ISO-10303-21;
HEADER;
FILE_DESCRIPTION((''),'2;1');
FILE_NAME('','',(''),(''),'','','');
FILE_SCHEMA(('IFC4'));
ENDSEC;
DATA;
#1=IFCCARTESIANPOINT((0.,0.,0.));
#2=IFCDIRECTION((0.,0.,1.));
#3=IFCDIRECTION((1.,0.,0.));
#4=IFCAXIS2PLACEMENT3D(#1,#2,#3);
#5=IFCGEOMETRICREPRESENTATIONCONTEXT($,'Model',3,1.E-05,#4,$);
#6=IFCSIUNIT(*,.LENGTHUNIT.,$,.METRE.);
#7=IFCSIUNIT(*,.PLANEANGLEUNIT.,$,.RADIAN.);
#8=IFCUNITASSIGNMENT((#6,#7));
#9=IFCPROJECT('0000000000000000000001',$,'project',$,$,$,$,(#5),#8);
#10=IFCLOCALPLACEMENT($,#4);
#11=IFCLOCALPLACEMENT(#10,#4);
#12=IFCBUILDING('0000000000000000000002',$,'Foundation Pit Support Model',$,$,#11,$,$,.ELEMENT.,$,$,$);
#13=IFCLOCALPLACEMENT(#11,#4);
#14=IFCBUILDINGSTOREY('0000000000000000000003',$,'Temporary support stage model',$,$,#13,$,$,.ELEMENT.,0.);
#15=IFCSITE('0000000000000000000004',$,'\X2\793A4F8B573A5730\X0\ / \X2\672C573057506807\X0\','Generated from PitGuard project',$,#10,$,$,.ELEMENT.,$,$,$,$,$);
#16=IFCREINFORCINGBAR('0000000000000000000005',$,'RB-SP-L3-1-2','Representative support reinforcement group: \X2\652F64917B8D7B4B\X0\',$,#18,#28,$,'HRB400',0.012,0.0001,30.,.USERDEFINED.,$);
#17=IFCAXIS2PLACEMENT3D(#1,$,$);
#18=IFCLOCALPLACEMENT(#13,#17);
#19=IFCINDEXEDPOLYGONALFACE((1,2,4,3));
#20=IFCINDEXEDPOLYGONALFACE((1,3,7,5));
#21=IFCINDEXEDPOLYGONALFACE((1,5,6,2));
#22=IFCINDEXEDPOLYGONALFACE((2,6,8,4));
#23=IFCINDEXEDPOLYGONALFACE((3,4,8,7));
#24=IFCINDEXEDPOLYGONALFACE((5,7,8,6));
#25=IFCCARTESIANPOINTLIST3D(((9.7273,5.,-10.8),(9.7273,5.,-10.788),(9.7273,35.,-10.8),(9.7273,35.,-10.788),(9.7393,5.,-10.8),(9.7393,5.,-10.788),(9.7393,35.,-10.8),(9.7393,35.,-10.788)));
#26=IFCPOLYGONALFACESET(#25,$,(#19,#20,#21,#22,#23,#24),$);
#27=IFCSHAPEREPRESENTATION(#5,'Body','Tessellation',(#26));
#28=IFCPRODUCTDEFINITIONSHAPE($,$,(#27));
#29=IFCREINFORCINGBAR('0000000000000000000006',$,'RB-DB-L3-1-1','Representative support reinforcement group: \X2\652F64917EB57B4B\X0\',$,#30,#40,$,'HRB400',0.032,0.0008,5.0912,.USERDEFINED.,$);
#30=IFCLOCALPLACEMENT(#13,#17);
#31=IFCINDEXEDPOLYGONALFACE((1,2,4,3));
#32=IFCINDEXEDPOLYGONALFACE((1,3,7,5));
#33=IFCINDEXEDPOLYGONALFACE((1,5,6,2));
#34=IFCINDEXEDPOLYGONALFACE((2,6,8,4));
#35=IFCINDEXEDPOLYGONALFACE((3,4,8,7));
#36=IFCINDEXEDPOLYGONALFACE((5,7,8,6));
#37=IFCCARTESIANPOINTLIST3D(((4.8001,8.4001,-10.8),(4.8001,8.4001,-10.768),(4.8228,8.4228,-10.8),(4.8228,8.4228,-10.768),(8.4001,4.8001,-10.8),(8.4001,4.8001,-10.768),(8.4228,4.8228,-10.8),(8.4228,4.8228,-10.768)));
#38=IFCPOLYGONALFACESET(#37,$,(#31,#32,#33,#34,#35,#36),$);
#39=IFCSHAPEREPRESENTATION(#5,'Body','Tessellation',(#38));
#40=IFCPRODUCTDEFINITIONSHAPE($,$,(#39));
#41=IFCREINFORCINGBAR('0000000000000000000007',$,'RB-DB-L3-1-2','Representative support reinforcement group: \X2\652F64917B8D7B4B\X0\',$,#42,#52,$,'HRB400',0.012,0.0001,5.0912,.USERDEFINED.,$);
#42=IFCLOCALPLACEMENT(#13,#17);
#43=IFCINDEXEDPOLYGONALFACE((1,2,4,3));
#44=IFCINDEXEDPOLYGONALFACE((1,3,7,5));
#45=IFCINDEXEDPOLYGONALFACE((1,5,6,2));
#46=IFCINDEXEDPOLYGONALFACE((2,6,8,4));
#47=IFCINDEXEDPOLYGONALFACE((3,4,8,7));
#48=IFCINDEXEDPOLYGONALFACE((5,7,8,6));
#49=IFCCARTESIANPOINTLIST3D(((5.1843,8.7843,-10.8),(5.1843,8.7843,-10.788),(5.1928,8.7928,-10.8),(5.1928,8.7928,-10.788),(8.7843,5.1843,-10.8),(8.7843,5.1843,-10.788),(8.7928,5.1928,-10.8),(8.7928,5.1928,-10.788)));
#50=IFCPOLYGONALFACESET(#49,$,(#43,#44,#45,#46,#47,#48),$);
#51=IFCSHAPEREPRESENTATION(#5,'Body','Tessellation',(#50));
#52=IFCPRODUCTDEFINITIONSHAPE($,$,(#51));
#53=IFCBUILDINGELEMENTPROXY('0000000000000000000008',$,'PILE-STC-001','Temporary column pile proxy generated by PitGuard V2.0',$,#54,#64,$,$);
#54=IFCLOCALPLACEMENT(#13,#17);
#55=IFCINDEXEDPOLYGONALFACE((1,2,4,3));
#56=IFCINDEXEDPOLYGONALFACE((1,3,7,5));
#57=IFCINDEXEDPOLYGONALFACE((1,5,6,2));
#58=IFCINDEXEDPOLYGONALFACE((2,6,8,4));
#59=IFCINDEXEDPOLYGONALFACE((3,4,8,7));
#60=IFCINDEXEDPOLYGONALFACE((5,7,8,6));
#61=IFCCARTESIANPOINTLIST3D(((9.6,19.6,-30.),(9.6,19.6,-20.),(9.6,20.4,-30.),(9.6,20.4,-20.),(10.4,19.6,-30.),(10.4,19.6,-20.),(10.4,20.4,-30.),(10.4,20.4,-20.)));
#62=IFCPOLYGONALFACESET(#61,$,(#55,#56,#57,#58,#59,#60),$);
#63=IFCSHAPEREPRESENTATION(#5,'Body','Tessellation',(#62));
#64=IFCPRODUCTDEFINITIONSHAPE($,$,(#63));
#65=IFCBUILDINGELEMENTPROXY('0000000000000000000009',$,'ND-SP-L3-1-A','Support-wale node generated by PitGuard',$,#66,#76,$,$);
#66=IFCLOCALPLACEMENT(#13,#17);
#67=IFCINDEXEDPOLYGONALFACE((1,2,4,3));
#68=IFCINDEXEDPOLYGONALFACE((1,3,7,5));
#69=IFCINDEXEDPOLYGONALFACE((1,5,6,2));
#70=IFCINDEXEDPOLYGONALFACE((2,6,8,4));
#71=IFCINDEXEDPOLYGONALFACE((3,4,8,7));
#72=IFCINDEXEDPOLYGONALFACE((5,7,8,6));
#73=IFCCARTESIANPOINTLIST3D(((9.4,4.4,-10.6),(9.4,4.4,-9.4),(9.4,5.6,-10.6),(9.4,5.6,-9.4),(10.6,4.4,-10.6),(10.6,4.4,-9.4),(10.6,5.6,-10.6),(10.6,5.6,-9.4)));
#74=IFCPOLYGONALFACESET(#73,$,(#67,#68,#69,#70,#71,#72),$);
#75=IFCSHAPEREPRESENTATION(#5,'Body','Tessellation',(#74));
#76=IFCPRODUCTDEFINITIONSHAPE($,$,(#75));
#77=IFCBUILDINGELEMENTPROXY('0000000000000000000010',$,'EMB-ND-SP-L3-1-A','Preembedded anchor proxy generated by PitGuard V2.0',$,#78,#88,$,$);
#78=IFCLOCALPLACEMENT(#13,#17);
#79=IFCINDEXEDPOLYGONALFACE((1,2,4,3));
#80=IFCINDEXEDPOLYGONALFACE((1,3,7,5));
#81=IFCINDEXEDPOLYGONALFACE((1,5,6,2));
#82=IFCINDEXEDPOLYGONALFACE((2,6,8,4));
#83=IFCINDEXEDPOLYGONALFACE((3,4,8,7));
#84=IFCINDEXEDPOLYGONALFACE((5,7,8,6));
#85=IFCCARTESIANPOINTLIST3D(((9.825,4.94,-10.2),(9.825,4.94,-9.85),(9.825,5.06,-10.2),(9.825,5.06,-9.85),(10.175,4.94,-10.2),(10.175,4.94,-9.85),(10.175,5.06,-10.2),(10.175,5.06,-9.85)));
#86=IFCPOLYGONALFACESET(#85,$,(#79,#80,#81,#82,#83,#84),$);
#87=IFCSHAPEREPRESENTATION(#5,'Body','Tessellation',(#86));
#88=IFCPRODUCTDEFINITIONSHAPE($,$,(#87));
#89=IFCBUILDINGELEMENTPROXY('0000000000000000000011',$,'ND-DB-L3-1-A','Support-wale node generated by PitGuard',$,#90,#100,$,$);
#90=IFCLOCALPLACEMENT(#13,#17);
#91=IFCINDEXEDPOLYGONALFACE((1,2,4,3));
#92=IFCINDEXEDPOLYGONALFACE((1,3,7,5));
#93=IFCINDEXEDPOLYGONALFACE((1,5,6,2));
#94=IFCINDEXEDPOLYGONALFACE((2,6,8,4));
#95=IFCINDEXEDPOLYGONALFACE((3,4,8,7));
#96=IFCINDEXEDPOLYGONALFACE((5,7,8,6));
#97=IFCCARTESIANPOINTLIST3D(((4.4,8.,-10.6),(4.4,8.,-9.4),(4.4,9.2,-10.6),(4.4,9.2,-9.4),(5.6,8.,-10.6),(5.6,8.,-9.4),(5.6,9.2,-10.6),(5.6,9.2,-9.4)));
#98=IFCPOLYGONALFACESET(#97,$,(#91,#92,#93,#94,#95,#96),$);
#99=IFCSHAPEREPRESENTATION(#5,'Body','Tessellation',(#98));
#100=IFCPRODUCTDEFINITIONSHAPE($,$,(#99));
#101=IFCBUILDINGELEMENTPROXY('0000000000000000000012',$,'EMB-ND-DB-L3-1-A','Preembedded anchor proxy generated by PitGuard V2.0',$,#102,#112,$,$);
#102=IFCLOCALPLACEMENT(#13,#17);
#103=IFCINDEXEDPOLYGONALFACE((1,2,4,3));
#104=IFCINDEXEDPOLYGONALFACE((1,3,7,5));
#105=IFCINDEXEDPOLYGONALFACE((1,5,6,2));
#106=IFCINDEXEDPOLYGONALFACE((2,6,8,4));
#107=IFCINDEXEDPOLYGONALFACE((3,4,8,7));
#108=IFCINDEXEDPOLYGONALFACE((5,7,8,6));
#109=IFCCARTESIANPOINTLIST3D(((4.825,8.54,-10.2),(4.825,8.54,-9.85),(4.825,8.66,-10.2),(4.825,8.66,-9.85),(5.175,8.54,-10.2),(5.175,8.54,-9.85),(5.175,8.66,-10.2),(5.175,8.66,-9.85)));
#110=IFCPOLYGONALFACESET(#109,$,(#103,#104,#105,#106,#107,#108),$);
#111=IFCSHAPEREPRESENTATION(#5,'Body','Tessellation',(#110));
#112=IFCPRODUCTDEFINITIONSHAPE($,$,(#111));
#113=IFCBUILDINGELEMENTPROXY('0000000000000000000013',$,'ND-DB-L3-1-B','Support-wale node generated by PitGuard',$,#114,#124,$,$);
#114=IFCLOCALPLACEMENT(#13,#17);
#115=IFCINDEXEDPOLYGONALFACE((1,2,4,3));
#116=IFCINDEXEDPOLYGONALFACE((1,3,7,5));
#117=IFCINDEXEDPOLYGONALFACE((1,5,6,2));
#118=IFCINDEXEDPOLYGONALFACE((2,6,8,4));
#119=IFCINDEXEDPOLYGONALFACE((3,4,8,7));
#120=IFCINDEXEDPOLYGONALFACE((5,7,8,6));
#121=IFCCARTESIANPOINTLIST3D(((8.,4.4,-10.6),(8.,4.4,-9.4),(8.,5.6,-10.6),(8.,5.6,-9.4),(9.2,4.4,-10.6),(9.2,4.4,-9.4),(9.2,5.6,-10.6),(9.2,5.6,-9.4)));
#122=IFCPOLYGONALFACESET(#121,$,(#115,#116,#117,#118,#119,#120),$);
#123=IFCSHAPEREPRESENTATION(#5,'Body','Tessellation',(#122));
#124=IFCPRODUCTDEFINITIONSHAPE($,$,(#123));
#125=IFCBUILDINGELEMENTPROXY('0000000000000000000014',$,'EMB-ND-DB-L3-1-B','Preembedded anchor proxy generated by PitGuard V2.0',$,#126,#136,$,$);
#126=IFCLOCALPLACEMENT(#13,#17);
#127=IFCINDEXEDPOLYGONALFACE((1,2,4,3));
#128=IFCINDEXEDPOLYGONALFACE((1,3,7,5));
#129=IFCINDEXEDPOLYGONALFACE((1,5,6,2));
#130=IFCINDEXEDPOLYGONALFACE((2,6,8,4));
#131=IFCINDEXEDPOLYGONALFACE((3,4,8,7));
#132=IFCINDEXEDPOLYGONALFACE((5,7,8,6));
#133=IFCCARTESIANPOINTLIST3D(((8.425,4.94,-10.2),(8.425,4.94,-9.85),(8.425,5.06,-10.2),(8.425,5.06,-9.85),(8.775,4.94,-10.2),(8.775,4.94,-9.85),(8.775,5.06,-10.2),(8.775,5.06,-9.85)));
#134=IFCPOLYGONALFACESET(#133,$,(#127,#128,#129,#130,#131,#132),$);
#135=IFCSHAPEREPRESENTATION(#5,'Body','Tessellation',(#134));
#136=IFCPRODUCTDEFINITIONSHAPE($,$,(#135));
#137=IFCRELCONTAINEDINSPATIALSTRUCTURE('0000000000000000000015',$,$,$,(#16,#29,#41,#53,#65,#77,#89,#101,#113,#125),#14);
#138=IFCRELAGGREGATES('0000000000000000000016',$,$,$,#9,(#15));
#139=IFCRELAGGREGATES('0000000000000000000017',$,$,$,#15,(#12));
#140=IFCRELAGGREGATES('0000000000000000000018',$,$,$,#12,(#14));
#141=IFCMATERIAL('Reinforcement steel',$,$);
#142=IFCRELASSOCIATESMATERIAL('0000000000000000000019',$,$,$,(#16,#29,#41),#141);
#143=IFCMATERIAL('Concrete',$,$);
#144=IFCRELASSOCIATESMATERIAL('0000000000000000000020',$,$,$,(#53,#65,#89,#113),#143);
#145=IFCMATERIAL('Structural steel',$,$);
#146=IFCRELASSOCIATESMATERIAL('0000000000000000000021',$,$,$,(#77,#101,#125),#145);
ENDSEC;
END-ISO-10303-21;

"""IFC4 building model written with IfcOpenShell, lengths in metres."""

from ifc_helpers import new_model, si_unit, frame, origin_with_axes, origin_2d, place, context, project, spatial, rectangle, extrude, material, element, save


model = new_model("IFC4")

# Units and contexts
model_context = context("Model", 3, precision=1e-05, world=origin_with_axes())
ifc_project = project(units=[si_unit("LENGTHUNIT", "METRE"), si_unit("PLANEANGLEUNIT", "RADIAN")], contexts=[model_context])

# Site, building, storey
site_placement = place(None, origin_with_axes())
site = spatial("IfcSite", under=ifc_project, at=site_placement, Name="示例场地 / 本地坐标", Description="Generated from PitGuard project", CompositionType="ELEMENT")
building_placement = place(site_placement, origin_with_axes())
building = spatial("IfcBuilding", under=site, at=building_placement, Name="Foundation Pit Support Model", CompositionType="ELEMENT")
storey_placement = place(building_placement, origin_with_axes())
storey = spatial("IfcBuildingStorey", under=building, at=storey_placement, Name="Temporary support stage model", CompositionType="ELEMENT", Elevation=0.0)

# Shared definitions
ifc_material_1 = material(Name="Structural steel")

# Shared definitions
ifc_material_2 = material(Name="Concrete")

# Reinforcing bars
ifc_material_3 = material(Name="Reinforcement steel")
reinforcing_bar_1_placement = place(storey_placement, frame((9.7333, 20.0, -10.8), z_axis=(0.0, 0.0, 1.0), x_axis=(0.0, 1.0, 0.0)))
element("IfcReinforcingBar", 1, at=reinforcing_bar_1_placement, inside=storey, material=ifc_material_3, Name="RB-SP-L3-1-2", Description="Representative support reinforcement group: 支撑箍筋", SteelGrade="HRB400", BarLength=30.0, CrossSectionArea=0.0001, NominalDiameter=0.012, PredefinedType="USERDEFINED", context=model_context, shape_type="SweptSolid", body=[
    extrude(rectangle(XDim=30.0, YDim=0.012, at=origin_2d()), origin_with_axes(), (0.0, 0.0, 1.0), 0.012),
])
reinforcing_bar_2_placement = place(storey_placement, frame((6.6114, 6.6114, -10.8), z_axis=(0.0, 0.0, 1.0), x_axis=(0.707107, -0.707107, 0.0)))
element("IfcReinforcingBar", 2, at=reinforcing_bar_2_placement, inside=storey, material=ifc_material_3, Name="RB-DB-L3-1-1", Description="Representative support reinforcement group: 支撑纵筋", SteelGrade="HRB400", BarLength=5.0912, CrossSectionArea=0.0008, NominalDiameter=0.032, PredefinedType="USERDEFINED", context=model_context, shape_type="SweptSolid", body=[
    extrude(rectangle(XDim=5.0912, YDim=0.032, at=origin_2d()), origin_with_axes(), (0.0, 0.0, 1.0), 0.032),
])
reinforcing_bar_3_placement = place(storey_placement, frame((6.9886, 6.9886, -10.8), z_axis=(0.0, 0.0, 1.0), x_axis=(0.707107, -0.707107, 0.0)))
element("IfcReinforcingBar", 3, at=reinforcing_bar_3_placement, inside=storey, material=ifc_material_3, Name="RB-DB-L3-1-2", Description="Representative support reinforcement group: 支撑箍筋", SteelGrade="HRB400", BarLength=5.0912, CrossSectionArea=0.0001, NominalDiameter=0.012, PredefinedType="USERDEFINED", context=model_context, shape_type="SweptSolid", body=[
    extrude(rectangle(XDim=5.0912, YDim=0.012, at=origin_2d()), origin_with_axes(), (0.0, 0.0, 1.0), 0.012),
])

# Building element proxies
proxy_1_placement = place(storey_placement, frame((10.0, 20.0, -30.0), z_axis=(0.0, 0.0, 1.0), x_axis=(1.0, 0.0, 0.0)))
element("IfcBuildingElementProxy", 4, at=proxy_1_placement, inside=storey, material=ifc_material_2, Name="PILE-STC-001", Description="Temporary column pile proxy generated by PitGuard V2.0", context=model_context, shape_type="SweptSolid", body=[
    extrude(rectangle(XDim=0.8, YDim=0.8, at=origin_2d()), origin_with_axes(), (0.0, 0.0, 1.0), 10.0),
])
proxy_2_placement = place(storey_placement, frame((10.0, 5.0, -10.6), z_axis=(0.0, 0.0, 1.0), x_axis=(1.0, 0.0, 0.0)))
element("IfcBuildingElementProxy", 5, at=proxy_2_placement, inside=storey, material=ifc_material_2, Name="ND-SP-L3-1-A", Description="Support-wale node generated by PitGuard", context=model_context, shape_type="SweptSolid", body=[
    extrude(rectangle(XDim=1.2, YDim=1.2, at=origin_2d()), origin_with_axes(), (0.0, 0.0, 1.0), 1.2),
])
proxy_3_placement = place(storey_placement, frame((10.0, 5.0, -10.2), z_axis=(0.0, 0.0, 1.0), x_axis=(1.0, 0.0, 0.0)))
element("IfcBuildingElementProxy", 6, at=proxy_3_placement, inside=storey, material=ifc_material_1, Name="EMB-ND-SP-L3-1-A", Description="Preembedded anchor proxy generated by PitGuard V2.0", context=model_context, shape_type="SweptSolid", body=[
    extrude(rectangle(XDim=0.35, YDim=0.12, at=origin_2d()), origin_with_axes(), (0.0, 0.0, 1.0), 0.35),
])
proxy_4_placement = place(storey_placement, frame((5.0, 8.6, -10.6), z_axis=(0.0, 0.0, 1.0), x_axis=(1.0, 0.0, 0.0)))
element("IfcBuildingElementProxy", 7, at=proxy_4_placement, inside=storey, material=ifc_material_2, Name="ND-DB-L3-1-A", Description="Support-wale node generated by PitGuard", context=model_context, shape_type="SweptSolid", body=[
    extrude(rectangle(XDim=1.2, YDim=1.2, at=origin_2d()), origin_with_axes(), (0.0, 0.0, 1.0), 1.2),
])
proxy_5_placement = place(storey_placement, frame((5.0, 8.6, -10.2), z_axis=(0.0, 0.0, 1.0), x_axis=(1.0, 0.0, 0.0)))
element("IfcBuildingElementProxy", 8, at=proxy_5_placement, inside=storey, material=ifc_material_1, Name="EMB-ND-DB-L3-1-A", Description="Preembedded anchor proxy generated by PitGuard V2.0", context=model_context, shape_type="SweptSolid", body=[
    extrude(rectangle(XDim=0.35, YDim=0.12, at=origin_2d()), origin_with_axes(), (0.0, 0.0, 1.0), 0.35),
])
proxy_6_placement = place(storey_placement, frame((8.6, 5.0, -10.6), z_axis=(0.0, 0.0, 1.0), x_axis=(1.0, 0.0, 0.0)))
element("IfcBuildingElementProxy", 9, at=proxy_6_placement, inside=storey, material=ifc_material_2, Name="ND-DB-L3-1-B", Description="Support-wale node generated by PitGuard", context=model_context, shape_type="SweptSolid", body=[
    extrude(rectangle(XDim=1.2, YDim=1.2, at=origin_2d()), origin_with_axes(), (0.0, 0.0, 1.0), 1.2),
])
proxy_7_placement = place(storey_placement, frame((8.6, 5.0, -10.2), z_axis=(0.0, 0.0, 1.0), x_axis=(1.0, 0.0, 0.0)))
element("IfcBuildingElementProxy", 10, at=proxy_7_placement, inside=storey, material=ifc_material_1, Name="EMB-ND-DB-L3-1-B", Description="Preembedded anchor proxy generated by PitGuard V2.0", context=model_context, shape_type="SweptSolid", body=[
    extrude(rectangle(XDim=0.35, YDim=0.12, at=origin_2d()), origin_with_axes(), (0.0, 0.0, 1.0), 0.35),
])

save(model, "model.ifc")
